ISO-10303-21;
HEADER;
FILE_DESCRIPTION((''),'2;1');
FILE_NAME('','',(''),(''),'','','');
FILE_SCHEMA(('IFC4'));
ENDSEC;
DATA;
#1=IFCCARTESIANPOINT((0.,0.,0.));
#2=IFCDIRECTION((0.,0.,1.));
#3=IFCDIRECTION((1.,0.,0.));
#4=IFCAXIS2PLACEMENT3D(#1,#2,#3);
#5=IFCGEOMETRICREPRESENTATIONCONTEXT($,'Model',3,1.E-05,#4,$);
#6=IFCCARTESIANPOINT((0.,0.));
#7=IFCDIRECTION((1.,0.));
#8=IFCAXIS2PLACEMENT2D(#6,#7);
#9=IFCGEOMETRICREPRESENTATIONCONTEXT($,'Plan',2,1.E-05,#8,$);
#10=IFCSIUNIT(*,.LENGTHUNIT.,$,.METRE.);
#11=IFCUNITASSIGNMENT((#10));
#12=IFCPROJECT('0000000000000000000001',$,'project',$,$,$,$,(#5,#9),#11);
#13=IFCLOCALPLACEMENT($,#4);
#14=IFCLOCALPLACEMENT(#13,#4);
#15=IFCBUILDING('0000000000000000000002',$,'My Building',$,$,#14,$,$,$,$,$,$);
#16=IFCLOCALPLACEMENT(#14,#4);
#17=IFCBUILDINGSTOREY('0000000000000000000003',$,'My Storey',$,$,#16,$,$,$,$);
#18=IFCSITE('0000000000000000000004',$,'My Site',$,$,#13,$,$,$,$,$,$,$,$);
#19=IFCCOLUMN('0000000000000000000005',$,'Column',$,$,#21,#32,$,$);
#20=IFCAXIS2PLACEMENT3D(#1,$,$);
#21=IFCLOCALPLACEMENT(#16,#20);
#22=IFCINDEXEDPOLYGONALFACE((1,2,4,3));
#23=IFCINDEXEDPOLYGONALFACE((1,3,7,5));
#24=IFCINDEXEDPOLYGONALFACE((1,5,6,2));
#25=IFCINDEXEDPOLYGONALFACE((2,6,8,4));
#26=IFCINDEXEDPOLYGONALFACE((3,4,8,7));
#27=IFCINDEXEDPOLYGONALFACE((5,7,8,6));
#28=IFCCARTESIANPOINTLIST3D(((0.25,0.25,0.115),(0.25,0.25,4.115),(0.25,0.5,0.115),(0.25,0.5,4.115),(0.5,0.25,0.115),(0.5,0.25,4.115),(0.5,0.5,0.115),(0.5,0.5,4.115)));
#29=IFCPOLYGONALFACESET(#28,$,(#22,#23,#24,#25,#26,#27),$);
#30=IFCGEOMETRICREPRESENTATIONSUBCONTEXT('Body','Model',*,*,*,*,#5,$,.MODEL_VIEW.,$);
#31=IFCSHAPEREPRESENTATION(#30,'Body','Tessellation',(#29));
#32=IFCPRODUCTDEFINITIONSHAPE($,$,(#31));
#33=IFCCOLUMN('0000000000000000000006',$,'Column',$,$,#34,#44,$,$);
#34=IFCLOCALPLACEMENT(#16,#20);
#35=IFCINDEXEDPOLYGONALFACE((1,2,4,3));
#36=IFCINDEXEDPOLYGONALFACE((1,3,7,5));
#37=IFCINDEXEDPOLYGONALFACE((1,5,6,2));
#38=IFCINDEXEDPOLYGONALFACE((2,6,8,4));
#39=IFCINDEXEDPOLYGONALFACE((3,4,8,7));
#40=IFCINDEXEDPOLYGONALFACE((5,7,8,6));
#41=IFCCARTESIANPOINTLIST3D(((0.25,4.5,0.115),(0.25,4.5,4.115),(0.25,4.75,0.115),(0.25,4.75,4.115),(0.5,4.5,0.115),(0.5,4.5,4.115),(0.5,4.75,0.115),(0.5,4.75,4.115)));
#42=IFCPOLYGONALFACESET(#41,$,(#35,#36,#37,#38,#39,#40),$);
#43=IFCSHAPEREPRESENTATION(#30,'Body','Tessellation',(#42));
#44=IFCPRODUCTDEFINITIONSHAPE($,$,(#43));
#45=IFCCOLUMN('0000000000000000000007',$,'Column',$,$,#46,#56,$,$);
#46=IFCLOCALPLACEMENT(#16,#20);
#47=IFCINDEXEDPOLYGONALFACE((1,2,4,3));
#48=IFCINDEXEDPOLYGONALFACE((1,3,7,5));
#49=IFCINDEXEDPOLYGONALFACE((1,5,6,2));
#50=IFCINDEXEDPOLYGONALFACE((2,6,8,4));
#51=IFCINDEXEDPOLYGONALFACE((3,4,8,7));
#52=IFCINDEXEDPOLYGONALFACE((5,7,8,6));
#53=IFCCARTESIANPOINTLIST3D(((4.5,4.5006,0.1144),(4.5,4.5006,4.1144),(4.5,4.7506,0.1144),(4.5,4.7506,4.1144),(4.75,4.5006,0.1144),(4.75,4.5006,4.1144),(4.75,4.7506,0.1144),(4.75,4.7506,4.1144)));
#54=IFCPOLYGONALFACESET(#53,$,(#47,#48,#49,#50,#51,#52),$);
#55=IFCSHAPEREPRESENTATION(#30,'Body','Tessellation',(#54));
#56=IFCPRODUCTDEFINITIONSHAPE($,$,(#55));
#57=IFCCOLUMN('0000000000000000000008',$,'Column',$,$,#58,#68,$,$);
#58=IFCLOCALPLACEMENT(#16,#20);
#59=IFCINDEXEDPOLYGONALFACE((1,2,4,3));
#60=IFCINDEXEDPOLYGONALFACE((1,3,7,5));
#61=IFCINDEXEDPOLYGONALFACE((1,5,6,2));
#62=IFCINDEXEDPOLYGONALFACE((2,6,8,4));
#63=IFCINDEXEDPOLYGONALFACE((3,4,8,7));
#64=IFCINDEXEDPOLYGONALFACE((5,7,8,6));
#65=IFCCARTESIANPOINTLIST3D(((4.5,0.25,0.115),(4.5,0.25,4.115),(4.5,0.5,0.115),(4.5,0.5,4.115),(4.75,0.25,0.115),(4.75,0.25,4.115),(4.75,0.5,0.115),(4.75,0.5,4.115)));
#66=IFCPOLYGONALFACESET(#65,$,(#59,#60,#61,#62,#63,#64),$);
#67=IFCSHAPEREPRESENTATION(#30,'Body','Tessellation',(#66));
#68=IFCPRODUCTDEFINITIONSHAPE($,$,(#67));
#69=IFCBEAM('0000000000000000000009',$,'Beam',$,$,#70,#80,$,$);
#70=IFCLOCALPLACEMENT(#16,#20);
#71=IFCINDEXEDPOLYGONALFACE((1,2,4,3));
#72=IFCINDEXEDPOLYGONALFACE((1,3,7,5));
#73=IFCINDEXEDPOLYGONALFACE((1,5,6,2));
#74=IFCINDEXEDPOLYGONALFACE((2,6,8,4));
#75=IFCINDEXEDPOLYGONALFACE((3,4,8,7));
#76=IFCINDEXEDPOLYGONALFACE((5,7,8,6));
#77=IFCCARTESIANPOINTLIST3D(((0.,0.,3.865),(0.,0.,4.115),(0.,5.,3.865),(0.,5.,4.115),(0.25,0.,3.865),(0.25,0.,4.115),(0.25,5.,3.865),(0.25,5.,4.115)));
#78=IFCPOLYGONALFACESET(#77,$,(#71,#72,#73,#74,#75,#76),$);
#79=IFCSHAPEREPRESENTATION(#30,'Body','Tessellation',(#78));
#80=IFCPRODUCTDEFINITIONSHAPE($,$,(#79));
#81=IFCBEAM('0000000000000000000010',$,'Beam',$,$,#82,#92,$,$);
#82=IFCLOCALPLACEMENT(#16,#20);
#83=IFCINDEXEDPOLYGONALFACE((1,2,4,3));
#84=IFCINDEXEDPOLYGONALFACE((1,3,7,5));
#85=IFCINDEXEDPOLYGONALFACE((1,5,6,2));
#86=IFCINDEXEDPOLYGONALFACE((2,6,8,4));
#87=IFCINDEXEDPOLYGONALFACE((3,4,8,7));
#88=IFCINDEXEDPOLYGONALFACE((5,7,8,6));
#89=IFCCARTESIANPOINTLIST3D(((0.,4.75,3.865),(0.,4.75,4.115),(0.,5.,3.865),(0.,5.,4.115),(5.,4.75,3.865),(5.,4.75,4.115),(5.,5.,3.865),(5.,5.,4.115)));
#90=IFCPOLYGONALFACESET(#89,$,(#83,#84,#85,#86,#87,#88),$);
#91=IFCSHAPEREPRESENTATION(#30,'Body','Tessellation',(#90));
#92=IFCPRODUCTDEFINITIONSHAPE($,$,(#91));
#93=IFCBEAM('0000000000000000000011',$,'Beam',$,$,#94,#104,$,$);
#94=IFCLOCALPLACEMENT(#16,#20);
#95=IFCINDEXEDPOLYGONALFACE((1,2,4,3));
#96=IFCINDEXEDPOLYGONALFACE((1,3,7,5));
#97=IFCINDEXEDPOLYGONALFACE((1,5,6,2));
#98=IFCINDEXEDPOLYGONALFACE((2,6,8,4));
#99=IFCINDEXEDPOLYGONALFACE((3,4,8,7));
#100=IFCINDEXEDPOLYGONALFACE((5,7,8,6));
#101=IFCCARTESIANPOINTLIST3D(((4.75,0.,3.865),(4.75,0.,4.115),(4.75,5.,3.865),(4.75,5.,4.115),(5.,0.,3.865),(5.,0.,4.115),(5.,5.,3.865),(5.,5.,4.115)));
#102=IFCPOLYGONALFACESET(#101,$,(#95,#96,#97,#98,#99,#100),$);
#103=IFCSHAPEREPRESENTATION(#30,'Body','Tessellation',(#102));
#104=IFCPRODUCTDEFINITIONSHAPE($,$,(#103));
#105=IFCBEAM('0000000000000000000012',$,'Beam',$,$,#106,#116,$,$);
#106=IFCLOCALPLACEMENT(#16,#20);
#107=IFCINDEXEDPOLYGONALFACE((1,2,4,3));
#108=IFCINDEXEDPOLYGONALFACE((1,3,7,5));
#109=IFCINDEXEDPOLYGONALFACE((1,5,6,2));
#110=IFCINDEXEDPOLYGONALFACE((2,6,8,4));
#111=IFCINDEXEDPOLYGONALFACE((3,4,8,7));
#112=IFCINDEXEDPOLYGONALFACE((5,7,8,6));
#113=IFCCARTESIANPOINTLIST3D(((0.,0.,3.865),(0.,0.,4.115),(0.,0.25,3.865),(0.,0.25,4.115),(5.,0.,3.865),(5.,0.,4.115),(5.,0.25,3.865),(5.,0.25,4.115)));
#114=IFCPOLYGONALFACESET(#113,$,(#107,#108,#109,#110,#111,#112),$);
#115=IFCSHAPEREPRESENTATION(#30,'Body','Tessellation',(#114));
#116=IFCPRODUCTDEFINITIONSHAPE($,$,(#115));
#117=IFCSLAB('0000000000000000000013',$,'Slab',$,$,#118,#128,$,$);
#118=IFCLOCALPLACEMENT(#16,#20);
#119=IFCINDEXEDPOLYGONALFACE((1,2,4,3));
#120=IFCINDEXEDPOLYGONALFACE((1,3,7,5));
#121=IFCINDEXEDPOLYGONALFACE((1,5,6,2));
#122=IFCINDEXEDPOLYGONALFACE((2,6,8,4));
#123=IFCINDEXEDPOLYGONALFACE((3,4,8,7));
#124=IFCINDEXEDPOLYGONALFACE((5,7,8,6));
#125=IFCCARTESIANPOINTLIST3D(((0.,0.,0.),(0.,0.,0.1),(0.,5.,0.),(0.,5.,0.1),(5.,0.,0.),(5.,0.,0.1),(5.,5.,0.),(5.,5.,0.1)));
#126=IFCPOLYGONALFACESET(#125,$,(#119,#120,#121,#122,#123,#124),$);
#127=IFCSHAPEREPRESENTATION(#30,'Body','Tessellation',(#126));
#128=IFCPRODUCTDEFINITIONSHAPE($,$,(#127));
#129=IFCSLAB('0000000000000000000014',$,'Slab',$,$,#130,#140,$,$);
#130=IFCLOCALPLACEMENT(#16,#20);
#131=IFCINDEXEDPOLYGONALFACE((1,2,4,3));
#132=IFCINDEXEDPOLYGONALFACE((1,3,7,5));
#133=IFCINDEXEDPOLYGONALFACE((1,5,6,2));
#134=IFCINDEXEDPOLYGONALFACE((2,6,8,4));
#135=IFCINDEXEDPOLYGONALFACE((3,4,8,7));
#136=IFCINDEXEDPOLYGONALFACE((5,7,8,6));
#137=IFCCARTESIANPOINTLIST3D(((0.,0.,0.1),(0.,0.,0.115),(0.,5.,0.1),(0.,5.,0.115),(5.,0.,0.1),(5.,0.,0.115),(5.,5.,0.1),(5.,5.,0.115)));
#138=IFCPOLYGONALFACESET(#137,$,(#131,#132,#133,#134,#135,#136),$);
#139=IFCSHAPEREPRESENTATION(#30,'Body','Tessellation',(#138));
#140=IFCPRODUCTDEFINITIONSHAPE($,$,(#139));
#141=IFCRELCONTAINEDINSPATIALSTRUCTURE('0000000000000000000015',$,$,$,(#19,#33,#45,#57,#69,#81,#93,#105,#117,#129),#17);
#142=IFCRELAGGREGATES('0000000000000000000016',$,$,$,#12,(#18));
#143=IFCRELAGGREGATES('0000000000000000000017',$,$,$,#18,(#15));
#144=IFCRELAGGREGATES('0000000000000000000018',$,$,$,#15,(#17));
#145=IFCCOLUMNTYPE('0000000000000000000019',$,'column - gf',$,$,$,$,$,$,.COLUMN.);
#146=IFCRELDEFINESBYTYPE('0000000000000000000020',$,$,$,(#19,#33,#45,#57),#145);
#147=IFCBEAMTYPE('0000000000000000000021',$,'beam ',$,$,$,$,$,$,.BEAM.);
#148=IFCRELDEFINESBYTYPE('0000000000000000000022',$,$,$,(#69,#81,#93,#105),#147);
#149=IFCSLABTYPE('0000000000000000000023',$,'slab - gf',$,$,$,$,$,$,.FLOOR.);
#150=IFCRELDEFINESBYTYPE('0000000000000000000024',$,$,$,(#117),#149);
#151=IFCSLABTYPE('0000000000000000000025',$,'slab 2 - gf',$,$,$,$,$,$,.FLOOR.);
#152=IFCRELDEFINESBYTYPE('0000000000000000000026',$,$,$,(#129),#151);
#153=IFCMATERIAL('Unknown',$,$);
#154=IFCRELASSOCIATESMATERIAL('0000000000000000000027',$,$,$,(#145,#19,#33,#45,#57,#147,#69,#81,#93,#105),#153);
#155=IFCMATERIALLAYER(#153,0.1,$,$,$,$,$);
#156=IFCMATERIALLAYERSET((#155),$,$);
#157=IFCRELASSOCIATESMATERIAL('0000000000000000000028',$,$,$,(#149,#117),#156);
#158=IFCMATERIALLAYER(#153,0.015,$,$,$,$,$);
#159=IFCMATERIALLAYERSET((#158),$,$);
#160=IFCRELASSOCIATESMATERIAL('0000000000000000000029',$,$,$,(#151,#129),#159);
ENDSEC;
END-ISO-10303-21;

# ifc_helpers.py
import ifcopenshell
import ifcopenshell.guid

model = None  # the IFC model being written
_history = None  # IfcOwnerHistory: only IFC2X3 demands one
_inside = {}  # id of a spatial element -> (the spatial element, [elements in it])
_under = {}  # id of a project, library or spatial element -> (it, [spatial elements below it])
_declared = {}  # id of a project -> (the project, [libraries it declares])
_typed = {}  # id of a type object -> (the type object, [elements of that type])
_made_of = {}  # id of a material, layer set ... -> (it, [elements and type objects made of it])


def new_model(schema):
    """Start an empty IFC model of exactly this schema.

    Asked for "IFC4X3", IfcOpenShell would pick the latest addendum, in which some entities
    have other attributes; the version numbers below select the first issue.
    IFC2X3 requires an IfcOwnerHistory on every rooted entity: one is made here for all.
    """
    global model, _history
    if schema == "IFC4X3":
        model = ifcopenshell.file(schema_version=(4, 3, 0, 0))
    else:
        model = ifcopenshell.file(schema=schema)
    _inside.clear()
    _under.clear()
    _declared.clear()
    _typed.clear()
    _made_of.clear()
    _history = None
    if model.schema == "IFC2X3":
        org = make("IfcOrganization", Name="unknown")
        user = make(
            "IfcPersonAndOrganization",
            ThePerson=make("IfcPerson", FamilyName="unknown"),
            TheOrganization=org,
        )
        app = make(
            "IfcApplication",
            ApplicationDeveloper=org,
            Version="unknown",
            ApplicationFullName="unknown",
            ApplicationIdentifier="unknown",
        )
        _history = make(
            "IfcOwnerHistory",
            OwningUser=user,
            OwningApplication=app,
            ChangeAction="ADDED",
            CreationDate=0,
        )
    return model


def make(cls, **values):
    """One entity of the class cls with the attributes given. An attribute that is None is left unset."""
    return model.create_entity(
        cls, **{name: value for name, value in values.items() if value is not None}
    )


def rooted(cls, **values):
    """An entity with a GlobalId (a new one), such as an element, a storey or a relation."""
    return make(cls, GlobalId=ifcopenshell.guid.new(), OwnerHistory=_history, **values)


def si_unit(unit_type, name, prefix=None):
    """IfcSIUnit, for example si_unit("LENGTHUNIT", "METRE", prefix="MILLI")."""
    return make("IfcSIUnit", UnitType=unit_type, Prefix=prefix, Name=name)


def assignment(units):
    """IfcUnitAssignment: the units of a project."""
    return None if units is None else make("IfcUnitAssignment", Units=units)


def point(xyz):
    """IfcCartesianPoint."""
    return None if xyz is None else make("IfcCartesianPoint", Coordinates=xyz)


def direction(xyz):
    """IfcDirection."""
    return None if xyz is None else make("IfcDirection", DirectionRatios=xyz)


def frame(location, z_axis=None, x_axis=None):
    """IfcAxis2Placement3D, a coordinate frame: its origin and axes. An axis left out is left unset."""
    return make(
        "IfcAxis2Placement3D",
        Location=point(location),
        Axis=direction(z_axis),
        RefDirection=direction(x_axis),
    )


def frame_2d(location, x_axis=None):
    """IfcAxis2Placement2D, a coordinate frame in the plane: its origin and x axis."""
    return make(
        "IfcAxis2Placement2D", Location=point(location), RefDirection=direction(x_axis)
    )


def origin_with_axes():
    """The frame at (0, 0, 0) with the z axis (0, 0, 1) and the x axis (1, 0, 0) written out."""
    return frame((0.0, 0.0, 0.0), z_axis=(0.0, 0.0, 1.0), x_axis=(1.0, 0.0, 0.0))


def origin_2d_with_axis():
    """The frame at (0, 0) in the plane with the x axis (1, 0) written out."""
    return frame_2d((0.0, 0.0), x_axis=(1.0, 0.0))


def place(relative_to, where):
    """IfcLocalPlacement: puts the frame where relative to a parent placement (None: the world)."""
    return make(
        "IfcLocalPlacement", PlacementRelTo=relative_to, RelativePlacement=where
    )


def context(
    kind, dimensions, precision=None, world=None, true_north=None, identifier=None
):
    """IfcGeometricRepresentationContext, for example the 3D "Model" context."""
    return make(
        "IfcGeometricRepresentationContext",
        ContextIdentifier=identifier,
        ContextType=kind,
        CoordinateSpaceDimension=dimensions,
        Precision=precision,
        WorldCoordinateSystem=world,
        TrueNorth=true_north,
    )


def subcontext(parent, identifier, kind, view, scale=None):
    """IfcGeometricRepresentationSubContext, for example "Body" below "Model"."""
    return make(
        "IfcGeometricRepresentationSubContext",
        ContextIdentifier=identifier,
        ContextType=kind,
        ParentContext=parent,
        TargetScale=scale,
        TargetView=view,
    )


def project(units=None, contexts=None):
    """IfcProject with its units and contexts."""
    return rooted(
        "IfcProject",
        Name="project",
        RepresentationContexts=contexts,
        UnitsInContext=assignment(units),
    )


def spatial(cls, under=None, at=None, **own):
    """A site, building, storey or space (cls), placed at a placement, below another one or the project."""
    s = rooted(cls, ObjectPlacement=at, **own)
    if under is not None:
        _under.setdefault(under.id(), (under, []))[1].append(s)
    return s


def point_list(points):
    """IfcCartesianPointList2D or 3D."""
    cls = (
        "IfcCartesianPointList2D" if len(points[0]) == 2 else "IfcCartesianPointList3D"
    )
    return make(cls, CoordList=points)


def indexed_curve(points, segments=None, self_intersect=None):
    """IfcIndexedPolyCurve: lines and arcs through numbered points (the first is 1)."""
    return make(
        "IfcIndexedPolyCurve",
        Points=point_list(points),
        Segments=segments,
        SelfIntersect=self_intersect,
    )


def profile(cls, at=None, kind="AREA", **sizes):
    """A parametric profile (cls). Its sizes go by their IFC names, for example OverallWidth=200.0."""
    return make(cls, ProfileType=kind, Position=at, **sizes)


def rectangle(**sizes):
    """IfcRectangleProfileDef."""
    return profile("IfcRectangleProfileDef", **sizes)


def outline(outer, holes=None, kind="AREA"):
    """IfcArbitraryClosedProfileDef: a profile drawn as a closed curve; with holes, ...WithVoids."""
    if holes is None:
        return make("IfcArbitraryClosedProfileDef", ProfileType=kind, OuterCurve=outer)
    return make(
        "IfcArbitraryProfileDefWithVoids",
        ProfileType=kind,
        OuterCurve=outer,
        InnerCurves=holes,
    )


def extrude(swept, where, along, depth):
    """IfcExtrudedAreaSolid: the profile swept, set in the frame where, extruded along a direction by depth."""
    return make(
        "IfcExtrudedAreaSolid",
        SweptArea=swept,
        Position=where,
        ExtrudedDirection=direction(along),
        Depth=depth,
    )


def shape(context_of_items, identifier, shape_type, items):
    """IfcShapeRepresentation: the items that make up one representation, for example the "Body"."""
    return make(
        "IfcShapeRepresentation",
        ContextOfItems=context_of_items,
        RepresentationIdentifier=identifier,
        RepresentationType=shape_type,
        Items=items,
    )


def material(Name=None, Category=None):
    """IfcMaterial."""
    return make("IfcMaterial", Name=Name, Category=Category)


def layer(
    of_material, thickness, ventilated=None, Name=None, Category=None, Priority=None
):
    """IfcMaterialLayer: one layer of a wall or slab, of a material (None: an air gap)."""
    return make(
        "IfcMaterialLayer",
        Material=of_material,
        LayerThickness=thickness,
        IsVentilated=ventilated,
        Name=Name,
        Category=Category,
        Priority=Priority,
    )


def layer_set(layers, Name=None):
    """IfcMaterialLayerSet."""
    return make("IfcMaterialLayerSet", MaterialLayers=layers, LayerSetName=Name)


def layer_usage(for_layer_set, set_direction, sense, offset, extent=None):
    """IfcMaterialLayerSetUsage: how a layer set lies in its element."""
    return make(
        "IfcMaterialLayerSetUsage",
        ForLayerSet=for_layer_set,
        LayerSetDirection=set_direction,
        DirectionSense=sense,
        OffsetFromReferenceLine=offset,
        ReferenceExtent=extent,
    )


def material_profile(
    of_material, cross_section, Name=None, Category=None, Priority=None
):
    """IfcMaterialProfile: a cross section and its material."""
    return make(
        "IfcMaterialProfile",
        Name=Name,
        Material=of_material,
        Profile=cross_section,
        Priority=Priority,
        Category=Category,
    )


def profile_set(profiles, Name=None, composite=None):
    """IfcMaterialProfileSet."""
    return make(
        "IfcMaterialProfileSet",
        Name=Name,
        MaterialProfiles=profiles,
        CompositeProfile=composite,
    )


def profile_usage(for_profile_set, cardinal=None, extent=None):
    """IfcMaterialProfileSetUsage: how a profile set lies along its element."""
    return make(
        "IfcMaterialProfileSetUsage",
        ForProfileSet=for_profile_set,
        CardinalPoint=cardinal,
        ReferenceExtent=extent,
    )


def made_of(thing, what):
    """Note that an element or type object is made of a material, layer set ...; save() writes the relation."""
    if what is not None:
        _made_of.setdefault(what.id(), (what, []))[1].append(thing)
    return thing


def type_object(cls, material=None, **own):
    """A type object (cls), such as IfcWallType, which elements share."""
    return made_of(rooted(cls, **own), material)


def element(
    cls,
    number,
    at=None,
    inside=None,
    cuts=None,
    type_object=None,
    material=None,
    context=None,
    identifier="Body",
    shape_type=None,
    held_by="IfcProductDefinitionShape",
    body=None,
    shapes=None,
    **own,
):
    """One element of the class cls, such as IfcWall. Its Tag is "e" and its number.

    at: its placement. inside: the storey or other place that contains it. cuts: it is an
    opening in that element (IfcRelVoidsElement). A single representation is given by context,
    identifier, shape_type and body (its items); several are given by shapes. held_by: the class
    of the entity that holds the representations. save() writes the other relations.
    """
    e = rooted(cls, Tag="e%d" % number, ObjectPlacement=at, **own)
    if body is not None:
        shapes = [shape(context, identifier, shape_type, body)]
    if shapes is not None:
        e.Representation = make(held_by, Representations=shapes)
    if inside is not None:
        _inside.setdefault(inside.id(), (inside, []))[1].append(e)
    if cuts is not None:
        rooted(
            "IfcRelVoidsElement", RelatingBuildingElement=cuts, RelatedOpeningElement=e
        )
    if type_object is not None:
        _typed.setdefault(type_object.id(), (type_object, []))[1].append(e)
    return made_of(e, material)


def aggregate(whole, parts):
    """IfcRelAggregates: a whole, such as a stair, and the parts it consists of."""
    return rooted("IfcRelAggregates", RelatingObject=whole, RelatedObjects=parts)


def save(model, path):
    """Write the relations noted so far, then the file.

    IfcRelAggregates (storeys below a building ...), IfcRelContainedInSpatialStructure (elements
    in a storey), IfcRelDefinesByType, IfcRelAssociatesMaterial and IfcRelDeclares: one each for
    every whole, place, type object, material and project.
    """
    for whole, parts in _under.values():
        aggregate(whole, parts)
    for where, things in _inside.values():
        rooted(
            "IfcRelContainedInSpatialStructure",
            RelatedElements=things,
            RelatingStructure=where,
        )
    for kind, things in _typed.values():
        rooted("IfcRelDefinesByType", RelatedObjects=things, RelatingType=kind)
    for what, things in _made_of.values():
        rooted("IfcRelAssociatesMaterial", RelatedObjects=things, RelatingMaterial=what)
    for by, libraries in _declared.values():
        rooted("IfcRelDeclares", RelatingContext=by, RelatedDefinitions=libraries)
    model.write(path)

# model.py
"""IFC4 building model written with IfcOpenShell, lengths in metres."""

from ifc_helpers import new_model, si_unit, frame, origin_with_axes, origin_2d_with_axis, place, context, subcontext, project, spatial, indexed_curve, rectangle, outline, extrude, material, layer, layer_set, layer_usage, material_profile, profile_set, profile_usage, type_object, element, save


model = new_model("IFC4")

# Units and contexts
model_context = context("Model", 3, precision=1e-05, world=origin_with_axes())
plan_context = context("Plan", 2, precision=1e-05, world=origin_2d_with_axis())
body_context = subcontext(model_context, "Body", "Model", "MODEL_VIEW")
ifc_project = project(units=[si_unit("LENGTHUNIT", "METRE")], contexts=[model_context, plan_context])

# Site, building, storey
site_placement = place(None, origin_with_axes())
site = spatial("IfcSite", under=ifc_project, at=site_placement, Name="My Site")
building_placement = place(site_placement, origin_with_axes())
building = spatial("IfcBuilding", under=site, at=building_placement, Name="My Building")
storey_placement = place(building_placement, origin_with_axes())
storey = spatial("IfcBuildingStorey", under=building, at=storey_placement, Name="My Storey")

# Columns
ifc_material = material(Name="Unknown")
ifc_material_profile_1 = material_profile(ifc_material, rectangle(XDim=0.25, YDim=0.25))
ifc_profile_set_1 = profile_set([ifc_material_profile_1])
ifc_profile_usage_1 = profile_usage(ifc_profile_set_1, cardinal=9)
column_type = type_object("IfcColumnType", Name="column - gf", PredefinedType="COLUMN", material=ifc_profile_set_1)
column_1_placement = place(storey_placement, frame((0.25, 0.5, 0.115), z_axis=(0.0, 0.0, 1.0), x_axis=(1.0, 0.0, 0.0)))
element("IfcColumn", 1, at=column_1_placement, inside=storey, type_object=column_type, material=ifc_profile_usage_1, Name="Column", context=body_context, shape_type="SweptSolid", body=[
    extrude(rectangle(XDim=0.25, YDim=0.25), frame((0.125, -0.125, 0.0), z_axis=(0.0, 0.0, 1.0), x_axis=(1.0, 0.0, 0.0)), (0.0, 0.0, 1.0), 4.0),
])
ifc_profile_usage_2 = profile_usage(ifc_profile_set_1, cardinal=9)
column_2_placement = place(storey_placement, frame((0.25, 4.75, 0.115), z_axis=(0.0, 0.0, 1.0), x_axis=(1.0, 0.0, 0.0)))
element("IfcColumn", 2, at=column_2_placement, inside=storey, type_object=column_type, material=ifc_profile_usage_2, Name="Column", context=body_context, shape_type="SweptSolid", body=[
    extrude(rectangle(XDim=0.25, YDim=0.25), frame((0.125, -0.125, 0.0), z_axis=(0.0, 0.0, 1.0), x_axis=(1.0, 0.0, 0.0)), (0.0, 0.0, 1.0), 4.0),
])
ifc_profile_usage_3 = profile_usage(ifc_profile_set_1, cardinal=9)
column_3_placement = place(storey_placement, frame((4.5, 4.7506, 0.1144), z_axis=(0.0, 0.0, 1.0), x_axis=(1.0, 0.0, 0.0)))
element("IfcColumn", 3, at=column_3_placement, inside=storey, type_object=column_type, material=ifc_profile_usage_3, Name="Column", context=body_context, shape_type="SweptSolid", body=[
    extrude(rectangle(XDim=0.25, YDim=0.25), frame((0.125, -0.125, 0.0), z_axis=(0.0, 0.0, 1.0), x_axis=(1.0, 0.0, 0.0)), (0.0, 0.0, 1.0), 4.0),
])
ifc_profile_usage_4 = profile_usage(ifc_profile_set_1, cardinal=9)
column_4_placement = place(storey_placement, frame((4.5, 0.5, 0.115), z_axis=(0.0, 0.0, 1.0), x_axis=(1.0, 0.0, 0.0)))
element("IfcColumn", 4, at=column_4_placement, inside=storey, type_object=column_type, material=ifc_profile_usage_4, Name="Column", context=body_context, shape_type="SweptSolid", body=[
    extrude(rectangle(XDim=0.25, YDim=0.25), frame((0.125, -0.125, 0.0), z_axis=(0.0, 0.0, 1.0), x_axis=(1.0, 0.0, 0.0)), (0.0, 0.0, 1.0), 4.0),
])

# Beams
ifc_material_profile_2 = material_profile(ifc_material, rectangle(XDim=0.25, YDim=0.25))
ifc_profile_set_2 = profile_set([ifc_material_profile_2])
ifc_profile_usage_5 = profile_usage(ifc_profile_set_2, cardinal=3)
beam_type = type_object("IfcBeamType", Name="beam ", PredefinedType="BEAM", material=ifc_profile_set_2)
beam_1_placement = place(storey_placement, frame((0.25, 0.0, 3.865), z_axis=(0.0, 1.0, 0.0), x_axis=(-1.0, 0.0, 0.0)))
element("IfcBeam", 5, at=beam_1_placement, inside=storey, type_object=beam_type, material=ifc_profile_usage_5, Name="Beam", context=body_context, shape_type="SweptSolid", body=[
    extrude(rectangle(XDim=0.25, YDim=0.25), frame((0.125, 0.125, 0.0), z_axis=(0.0, 0.0, 1.0), x_axis=(1.0, 0.0, 0.0)), (0.0, 0.0, 1.0), 5.0),
])
ifc_profile_usage_6 = profile_usage(ifc_profile_set_2, cardinal=3)
beam_2_placement = place(storey_placement, frame((0.0, 4.75, 3.865), z_axis=(1.0, -0.000001, 0.000001), x_axis=(0.000001, 1.0, 0.0)))
element("IfcBeam", 6, at=beam_2_placement, inside=storey, type_object=beam_type, material=ifc_profile_usage_6, Name="Beam", context=body_context, shape_type="SweptSolid", body=[
    extrude(rectangle(XDim=0.25, YDim=0.25), frame((0.125, 0.125, 0.0), z_axis=(0.0, 0.0, 1.0), x_axis=(1.0, 0.0, 0.0)), (0.0, 0.0, 1.0), 5.0),
])
ifc_profile_usage_7 = profile_usage(ifc_profile_set_2, cardinal=3)
beam_3_placement = place(storey_placement, frame((5.0, 0.0, 3.865), z_axis=(0.0, 1.0, 0.0), x_axis=(-1.0, 0.0, 0.0)))
element("IfcBeam", 7, at=beam_3_placement, inside=storey, type_object=beam_type, material=ifc_profile_usage_7, Name="Beam", context=body_context, shape_type="SweptSolid", body=[
    extrude(rectangle(XDim=0.25, YDim=0.25), frame((0.125, 0.125, 0.0), z_axis=(0.0, 0.0, 1.0), x_axis=(1.0, 0.0, 0.0)), (0.0, 0.0, 1.0), 5.0),
])
ifc_profile_usage_8 = profile_usage(ifc_profile_set_2, cardinal=3)
beam_4_placement = place(storey_placement, frame((0.0, 0.0, 3.865), z_axis=(1.0, -0.000001, 0.000001), x_axis=(0.000001, 1.0, 0.0)))
element("IfcBeam", 8, at=beam_4_placement, inside=storey, type_object=beam_type, material=ifc_profile_usage_8, Name="Beam", context=body_context, shape_type="SweptSolid", body=[
    extrude(rectangle(XDim=0.25, YDim=0.25), frame((0.125, 0.125, 0.0), z_axis=(0.0, 0.0, 1.0), x_axis=(1.0, 0.0, 0.0)), (0.0, 0.0, 1.0), 5.0),
])

# Slabs
ifc_layer_1 = layer(ifc_material, 0.1)
ifc_layer_set_1 = layer_set([ifc_layer_1])
ifc_layer_usage_1 = layer_usage(ifc_layer_set_1, "AXIS3", "POSITIVE", 0.0)
slab_type_1 = type_object("IfcSlabType", Name="slab - gf", PredefinedType="FLOOR", material=ifc_layer_set_1)
slab_1_placement = place(storey_placement, origin_with_axes())
element("IfcSlab", 9, at=slab_1_placement, inside=storey, type_object=slab_type_1, material=ifc_layer_usage_1, Name="Slab", context=body_context, shape_type="SweptSolid", body=[
    extrude(outline(indexed_curve([(0.0, 0.0), (5.0, 0.0), (5.0, 5.0), (0.0, 5.0), (0.0, 0.0)])), origin_with_axes(), (0.0, 0.0, 1.0), 0.1),
])
ifc_layer_2 = layer(ifc_material, 0.015)
ifc_layer_set_2 = layer_set([ifc_layer_2])
ifc_layer_usage_2 = layer_usage(ifc_layer_set_2, "AXIS3", "POSITIVE", 0.1)
slab_type_2 = type_object("IfcSlabType", Name="slab 2 - gf", PredefinedType="FLOOR", material=ifc_layer_set_2)
slab_2_placement = place(storey_placement, frame((0.0, 5.0, 0.0), z_axis=(0.0, 0.0, 1.0), x_axis=(1.0, 0.0, 0.0)))
element("IfcSlab", 10, at=slab_2_placement, inside=storey, type_object=slab_type_2, material=ifc_layer_usage_2, Name="Slab", context=body_context, shape_type="SweptSolid", body=[
    extrude(outline(indexed_curve([(0.0, 0.0), (5.0, 0.0), (5.0, -5.0), (0.0, -5.0), (0.0, 0.0)])), frame((0.0, 0.0, 0.1), z_axis=(0.0, 0.0, 1.0), x_axis=(1.0, 0.0, 0.0)), (0.0, 0.0, 1.0), 0.015),
])

save(model, "model.ifc")
